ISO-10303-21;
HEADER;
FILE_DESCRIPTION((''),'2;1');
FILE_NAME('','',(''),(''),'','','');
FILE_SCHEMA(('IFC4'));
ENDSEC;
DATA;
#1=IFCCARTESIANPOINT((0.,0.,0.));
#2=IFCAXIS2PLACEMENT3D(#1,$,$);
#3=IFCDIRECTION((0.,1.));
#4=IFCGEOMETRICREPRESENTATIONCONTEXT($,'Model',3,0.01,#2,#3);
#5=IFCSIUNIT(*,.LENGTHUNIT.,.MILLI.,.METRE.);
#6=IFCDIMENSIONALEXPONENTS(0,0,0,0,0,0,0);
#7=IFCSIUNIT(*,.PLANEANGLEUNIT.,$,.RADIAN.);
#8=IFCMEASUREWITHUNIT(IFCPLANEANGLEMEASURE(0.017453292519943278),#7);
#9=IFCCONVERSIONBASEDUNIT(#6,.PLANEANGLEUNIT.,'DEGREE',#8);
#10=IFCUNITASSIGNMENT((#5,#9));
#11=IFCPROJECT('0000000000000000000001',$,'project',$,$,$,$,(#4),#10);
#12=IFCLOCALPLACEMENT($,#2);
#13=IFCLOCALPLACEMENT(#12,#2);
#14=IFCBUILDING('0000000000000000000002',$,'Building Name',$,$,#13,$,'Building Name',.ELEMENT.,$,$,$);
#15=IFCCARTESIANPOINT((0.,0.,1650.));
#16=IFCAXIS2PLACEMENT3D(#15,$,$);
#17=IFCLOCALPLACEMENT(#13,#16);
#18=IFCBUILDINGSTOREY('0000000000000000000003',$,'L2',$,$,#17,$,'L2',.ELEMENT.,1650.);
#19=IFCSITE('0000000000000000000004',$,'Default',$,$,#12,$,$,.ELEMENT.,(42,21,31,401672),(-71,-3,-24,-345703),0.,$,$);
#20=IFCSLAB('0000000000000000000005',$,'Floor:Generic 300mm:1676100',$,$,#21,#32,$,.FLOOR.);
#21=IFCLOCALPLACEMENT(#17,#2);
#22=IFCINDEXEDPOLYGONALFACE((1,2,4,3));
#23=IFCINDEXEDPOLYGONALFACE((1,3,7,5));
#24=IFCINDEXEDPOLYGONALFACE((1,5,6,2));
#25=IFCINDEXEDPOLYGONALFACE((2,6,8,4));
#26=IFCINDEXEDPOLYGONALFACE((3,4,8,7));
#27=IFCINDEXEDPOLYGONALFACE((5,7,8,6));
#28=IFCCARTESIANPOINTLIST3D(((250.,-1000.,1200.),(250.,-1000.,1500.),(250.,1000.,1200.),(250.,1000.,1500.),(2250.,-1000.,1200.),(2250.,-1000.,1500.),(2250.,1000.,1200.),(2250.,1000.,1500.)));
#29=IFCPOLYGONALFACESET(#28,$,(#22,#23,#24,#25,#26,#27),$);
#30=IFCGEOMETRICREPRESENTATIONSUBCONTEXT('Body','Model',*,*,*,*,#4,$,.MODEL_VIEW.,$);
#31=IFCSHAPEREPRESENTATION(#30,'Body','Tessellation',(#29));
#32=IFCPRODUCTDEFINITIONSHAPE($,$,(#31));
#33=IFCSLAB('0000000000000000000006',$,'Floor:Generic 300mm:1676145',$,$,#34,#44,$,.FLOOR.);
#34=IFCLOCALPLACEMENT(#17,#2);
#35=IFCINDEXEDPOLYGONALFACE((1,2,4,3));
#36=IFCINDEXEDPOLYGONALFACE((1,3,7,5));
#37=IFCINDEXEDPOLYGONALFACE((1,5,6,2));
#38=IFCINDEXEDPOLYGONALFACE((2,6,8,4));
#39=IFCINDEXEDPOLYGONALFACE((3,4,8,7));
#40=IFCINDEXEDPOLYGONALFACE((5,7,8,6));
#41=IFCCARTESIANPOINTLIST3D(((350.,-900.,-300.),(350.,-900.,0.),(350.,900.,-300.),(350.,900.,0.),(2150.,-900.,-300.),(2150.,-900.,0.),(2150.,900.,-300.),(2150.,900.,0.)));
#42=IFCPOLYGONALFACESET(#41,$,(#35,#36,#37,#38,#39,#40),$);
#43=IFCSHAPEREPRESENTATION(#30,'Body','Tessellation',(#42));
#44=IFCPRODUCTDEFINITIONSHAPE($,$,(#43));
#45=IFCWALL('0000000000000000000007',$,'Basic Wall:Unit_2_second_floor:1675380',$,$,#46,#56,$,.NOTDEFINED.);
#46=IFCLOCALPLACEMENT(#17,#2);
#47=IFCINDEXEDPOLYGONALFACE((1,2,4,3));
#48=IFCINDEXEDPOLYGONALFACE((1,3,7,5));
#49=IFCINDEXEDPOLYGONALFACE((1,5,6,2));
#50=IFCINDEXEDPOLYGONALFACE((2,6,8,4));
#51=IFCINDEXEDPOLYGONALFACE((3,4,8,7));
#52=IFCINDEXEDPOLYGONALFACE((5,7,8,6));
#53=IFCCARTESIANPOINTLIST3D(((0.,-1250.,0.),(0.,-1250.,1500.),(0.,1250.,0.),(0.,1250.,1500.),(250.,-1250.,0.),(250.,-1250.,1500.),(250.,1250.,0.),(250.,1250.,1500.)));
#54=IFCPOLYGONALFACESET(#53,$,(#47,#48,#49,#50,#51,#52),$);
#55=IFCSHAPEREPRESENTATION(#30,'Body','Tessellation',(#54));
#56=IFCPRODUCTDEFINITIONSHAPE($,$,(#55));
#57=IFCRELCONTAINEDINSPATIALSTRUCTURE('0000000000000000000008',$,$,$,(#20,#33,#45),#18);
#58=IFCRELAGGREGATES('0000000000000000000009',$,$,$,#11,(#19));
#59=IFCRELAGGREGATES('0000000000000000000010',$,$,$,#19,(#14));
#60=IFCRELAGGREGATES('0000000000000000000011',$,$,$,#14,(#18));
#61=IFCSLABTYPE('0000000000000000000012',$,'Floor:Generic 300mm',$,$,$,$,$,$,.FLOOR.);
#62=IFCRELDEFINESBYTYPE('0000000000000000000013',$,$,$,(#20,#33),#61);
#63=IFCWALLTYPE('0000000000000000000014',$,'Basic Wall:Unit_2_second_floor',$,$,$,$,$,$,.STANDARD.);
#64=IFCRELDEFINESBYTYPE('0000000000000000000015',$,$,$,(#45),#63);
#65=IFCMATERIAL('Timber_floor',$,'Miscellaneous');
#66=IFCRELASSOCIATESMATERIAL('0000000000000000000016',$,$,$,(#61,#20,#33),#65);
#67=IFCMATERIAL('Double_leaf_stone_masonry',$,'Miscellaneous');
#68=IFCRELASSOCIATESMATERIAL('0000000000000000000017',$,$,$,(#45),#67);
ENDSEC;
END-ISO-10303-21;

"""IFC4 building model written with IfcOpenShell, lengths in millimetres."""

from ifc_helpers import new_model, entity, si_unit, converted_unit, direction, frame, origin, place, context, subcontext, project, spatial, indexed_curve, outline, extrude, material, type_object, element, save


model = new_model("IFC4")

# Units and contexts
model_context = context("Model", 3, precision=0.01, world=origin(), true_north=direction((0.0, 1.0)))
body_context = subcontext(model_context, "Body", "Model", "MODEL_VIEW")
ifc_project = project(units=[si_unit("LENGTHUNIT", "METRE", prefix="MILLI"), converted_unit("PLANEANGLEUNIT", "DEGREE", entity("IfcPlaneAngleMeasure", 0.017453292519943278), si_unit("PLANEANGLEUNIT", "RADIAN"), dimensions=[0, 0, 0, 0, 0, 0, 0])], contexts=[model_context])

# Site, building, storey
site_placement = place(None, origin())
site = spatial("IfcSite", under=ifc_project, at=site_placement, Name="Default", CompositionType="ELEMENT", RefLatitude=(42, 21, 31, 401672), RefLongitude=(-71, -3, -24, -345703), RefElevation=0.0)
building_placement = place(site_placement, origin())
building = spatial("IfcBuilding", under=site, at=building_placement, Name="Building Name", LongName="Building Name", CompositionType="ELEMENT")
storey_placement = place(building_placement, frame((0.0, 0.0, 1650.0)))
storey = spatial("IfcBuildingStorey", under=building, at=storey_placement, Name="L2", LongName="L2", CompositionType="ELEMENT", Elevation=1650.0)

# Slabs
ifc_material_1 = material(Name="Timber_floor", Category="Miscellaneous")
slab_type = type_object("IfcSlabType", Name="Floor:Generic 300mm", PredefinedType="FLOOR", material=ifc_material_1)
slab_1_placement = place(storey_placement, origin())
element("IfcSlab", 1, at=slab_1_placement, inside=storey, type_object=slab_type, material=ifc_material_1, Name="Floor:Generic 300mm:1676100", PredefinedType="FLOOR", context=body_context, shape_type="SweptSolid", body=[
    extrude(outline(indexed_curve([(-1000.0, -1000.0), (1000.0, -1000.0), (1000.0, 1000.0), (-1000.0, 1000.0), (-1000.0, -1000.0)], self_intersect=False)), frame((1250.0, 0.0, 1500.0), z_axis=(0.0, 0.0, -1.0), x_axis=(0.0, 1.0, 0.0)), (0.0, 0.0, 1.0), 300.0),
])
slab_2_placement = place(storey_placement, origin())
element("IfcSlab", 2, at=slab_2_placement, inside=storey, type_object=slab_type, material=ifc_material_1, Name="Floor:Generic 300mm:1676145", PredefinedType="FLOOR", context=body_context, shape_type="SweptSolid", body=[
    extrude(outline(indexed_curve([(-900.0, -900.0), (900.0, -900.0), (900.0, 900.0), (-900.0, 900.0), (-900.0, -900.0)], self_intersect=False)), frame((1250.0, 0.0, 0.0), z_axis=(0.0, 0.0, -1.0), x_axis=(0.0, 1.0, 0.0)), (0.0, 0.0, 1.0), 300.0),
])

# Wall
ifc_material_2 = material(Name="Double_leaf_stone_masonry", Category="Miscellaneous")
wall_type = type_object("IfcWallType", Name="Basic Wall:Unit_2_second_floor", PredefinedType="STANDARD")
wall_placement = place(storey_placement, frame((125.0, 1250.0, 0.0), z_axis=(0.0, 0.0, 1.0), x_axis=(0.0, -1.0, 0.0)))
element("IfcWall", 3, at=wall_placement, inside=storey, type_object=wall_type, material=ifc_material_2, Name="Basic Wall:Unit_2_second_floor:1675380", PredefinedType="NOTDEFINED", context=body_context, shape_type="SweptSolid", body=[
    extrude(outline(indexed_curve([(2500.0, 125.0), (0.0, 125.0), (0.0, -125.0), (2500.0, -125.0), (2500.0, 125.0)], self_intersect=False)), origin(), (0.0, 0.0, 1.0), 1500.0),
])

save(model, "model.ifc")
